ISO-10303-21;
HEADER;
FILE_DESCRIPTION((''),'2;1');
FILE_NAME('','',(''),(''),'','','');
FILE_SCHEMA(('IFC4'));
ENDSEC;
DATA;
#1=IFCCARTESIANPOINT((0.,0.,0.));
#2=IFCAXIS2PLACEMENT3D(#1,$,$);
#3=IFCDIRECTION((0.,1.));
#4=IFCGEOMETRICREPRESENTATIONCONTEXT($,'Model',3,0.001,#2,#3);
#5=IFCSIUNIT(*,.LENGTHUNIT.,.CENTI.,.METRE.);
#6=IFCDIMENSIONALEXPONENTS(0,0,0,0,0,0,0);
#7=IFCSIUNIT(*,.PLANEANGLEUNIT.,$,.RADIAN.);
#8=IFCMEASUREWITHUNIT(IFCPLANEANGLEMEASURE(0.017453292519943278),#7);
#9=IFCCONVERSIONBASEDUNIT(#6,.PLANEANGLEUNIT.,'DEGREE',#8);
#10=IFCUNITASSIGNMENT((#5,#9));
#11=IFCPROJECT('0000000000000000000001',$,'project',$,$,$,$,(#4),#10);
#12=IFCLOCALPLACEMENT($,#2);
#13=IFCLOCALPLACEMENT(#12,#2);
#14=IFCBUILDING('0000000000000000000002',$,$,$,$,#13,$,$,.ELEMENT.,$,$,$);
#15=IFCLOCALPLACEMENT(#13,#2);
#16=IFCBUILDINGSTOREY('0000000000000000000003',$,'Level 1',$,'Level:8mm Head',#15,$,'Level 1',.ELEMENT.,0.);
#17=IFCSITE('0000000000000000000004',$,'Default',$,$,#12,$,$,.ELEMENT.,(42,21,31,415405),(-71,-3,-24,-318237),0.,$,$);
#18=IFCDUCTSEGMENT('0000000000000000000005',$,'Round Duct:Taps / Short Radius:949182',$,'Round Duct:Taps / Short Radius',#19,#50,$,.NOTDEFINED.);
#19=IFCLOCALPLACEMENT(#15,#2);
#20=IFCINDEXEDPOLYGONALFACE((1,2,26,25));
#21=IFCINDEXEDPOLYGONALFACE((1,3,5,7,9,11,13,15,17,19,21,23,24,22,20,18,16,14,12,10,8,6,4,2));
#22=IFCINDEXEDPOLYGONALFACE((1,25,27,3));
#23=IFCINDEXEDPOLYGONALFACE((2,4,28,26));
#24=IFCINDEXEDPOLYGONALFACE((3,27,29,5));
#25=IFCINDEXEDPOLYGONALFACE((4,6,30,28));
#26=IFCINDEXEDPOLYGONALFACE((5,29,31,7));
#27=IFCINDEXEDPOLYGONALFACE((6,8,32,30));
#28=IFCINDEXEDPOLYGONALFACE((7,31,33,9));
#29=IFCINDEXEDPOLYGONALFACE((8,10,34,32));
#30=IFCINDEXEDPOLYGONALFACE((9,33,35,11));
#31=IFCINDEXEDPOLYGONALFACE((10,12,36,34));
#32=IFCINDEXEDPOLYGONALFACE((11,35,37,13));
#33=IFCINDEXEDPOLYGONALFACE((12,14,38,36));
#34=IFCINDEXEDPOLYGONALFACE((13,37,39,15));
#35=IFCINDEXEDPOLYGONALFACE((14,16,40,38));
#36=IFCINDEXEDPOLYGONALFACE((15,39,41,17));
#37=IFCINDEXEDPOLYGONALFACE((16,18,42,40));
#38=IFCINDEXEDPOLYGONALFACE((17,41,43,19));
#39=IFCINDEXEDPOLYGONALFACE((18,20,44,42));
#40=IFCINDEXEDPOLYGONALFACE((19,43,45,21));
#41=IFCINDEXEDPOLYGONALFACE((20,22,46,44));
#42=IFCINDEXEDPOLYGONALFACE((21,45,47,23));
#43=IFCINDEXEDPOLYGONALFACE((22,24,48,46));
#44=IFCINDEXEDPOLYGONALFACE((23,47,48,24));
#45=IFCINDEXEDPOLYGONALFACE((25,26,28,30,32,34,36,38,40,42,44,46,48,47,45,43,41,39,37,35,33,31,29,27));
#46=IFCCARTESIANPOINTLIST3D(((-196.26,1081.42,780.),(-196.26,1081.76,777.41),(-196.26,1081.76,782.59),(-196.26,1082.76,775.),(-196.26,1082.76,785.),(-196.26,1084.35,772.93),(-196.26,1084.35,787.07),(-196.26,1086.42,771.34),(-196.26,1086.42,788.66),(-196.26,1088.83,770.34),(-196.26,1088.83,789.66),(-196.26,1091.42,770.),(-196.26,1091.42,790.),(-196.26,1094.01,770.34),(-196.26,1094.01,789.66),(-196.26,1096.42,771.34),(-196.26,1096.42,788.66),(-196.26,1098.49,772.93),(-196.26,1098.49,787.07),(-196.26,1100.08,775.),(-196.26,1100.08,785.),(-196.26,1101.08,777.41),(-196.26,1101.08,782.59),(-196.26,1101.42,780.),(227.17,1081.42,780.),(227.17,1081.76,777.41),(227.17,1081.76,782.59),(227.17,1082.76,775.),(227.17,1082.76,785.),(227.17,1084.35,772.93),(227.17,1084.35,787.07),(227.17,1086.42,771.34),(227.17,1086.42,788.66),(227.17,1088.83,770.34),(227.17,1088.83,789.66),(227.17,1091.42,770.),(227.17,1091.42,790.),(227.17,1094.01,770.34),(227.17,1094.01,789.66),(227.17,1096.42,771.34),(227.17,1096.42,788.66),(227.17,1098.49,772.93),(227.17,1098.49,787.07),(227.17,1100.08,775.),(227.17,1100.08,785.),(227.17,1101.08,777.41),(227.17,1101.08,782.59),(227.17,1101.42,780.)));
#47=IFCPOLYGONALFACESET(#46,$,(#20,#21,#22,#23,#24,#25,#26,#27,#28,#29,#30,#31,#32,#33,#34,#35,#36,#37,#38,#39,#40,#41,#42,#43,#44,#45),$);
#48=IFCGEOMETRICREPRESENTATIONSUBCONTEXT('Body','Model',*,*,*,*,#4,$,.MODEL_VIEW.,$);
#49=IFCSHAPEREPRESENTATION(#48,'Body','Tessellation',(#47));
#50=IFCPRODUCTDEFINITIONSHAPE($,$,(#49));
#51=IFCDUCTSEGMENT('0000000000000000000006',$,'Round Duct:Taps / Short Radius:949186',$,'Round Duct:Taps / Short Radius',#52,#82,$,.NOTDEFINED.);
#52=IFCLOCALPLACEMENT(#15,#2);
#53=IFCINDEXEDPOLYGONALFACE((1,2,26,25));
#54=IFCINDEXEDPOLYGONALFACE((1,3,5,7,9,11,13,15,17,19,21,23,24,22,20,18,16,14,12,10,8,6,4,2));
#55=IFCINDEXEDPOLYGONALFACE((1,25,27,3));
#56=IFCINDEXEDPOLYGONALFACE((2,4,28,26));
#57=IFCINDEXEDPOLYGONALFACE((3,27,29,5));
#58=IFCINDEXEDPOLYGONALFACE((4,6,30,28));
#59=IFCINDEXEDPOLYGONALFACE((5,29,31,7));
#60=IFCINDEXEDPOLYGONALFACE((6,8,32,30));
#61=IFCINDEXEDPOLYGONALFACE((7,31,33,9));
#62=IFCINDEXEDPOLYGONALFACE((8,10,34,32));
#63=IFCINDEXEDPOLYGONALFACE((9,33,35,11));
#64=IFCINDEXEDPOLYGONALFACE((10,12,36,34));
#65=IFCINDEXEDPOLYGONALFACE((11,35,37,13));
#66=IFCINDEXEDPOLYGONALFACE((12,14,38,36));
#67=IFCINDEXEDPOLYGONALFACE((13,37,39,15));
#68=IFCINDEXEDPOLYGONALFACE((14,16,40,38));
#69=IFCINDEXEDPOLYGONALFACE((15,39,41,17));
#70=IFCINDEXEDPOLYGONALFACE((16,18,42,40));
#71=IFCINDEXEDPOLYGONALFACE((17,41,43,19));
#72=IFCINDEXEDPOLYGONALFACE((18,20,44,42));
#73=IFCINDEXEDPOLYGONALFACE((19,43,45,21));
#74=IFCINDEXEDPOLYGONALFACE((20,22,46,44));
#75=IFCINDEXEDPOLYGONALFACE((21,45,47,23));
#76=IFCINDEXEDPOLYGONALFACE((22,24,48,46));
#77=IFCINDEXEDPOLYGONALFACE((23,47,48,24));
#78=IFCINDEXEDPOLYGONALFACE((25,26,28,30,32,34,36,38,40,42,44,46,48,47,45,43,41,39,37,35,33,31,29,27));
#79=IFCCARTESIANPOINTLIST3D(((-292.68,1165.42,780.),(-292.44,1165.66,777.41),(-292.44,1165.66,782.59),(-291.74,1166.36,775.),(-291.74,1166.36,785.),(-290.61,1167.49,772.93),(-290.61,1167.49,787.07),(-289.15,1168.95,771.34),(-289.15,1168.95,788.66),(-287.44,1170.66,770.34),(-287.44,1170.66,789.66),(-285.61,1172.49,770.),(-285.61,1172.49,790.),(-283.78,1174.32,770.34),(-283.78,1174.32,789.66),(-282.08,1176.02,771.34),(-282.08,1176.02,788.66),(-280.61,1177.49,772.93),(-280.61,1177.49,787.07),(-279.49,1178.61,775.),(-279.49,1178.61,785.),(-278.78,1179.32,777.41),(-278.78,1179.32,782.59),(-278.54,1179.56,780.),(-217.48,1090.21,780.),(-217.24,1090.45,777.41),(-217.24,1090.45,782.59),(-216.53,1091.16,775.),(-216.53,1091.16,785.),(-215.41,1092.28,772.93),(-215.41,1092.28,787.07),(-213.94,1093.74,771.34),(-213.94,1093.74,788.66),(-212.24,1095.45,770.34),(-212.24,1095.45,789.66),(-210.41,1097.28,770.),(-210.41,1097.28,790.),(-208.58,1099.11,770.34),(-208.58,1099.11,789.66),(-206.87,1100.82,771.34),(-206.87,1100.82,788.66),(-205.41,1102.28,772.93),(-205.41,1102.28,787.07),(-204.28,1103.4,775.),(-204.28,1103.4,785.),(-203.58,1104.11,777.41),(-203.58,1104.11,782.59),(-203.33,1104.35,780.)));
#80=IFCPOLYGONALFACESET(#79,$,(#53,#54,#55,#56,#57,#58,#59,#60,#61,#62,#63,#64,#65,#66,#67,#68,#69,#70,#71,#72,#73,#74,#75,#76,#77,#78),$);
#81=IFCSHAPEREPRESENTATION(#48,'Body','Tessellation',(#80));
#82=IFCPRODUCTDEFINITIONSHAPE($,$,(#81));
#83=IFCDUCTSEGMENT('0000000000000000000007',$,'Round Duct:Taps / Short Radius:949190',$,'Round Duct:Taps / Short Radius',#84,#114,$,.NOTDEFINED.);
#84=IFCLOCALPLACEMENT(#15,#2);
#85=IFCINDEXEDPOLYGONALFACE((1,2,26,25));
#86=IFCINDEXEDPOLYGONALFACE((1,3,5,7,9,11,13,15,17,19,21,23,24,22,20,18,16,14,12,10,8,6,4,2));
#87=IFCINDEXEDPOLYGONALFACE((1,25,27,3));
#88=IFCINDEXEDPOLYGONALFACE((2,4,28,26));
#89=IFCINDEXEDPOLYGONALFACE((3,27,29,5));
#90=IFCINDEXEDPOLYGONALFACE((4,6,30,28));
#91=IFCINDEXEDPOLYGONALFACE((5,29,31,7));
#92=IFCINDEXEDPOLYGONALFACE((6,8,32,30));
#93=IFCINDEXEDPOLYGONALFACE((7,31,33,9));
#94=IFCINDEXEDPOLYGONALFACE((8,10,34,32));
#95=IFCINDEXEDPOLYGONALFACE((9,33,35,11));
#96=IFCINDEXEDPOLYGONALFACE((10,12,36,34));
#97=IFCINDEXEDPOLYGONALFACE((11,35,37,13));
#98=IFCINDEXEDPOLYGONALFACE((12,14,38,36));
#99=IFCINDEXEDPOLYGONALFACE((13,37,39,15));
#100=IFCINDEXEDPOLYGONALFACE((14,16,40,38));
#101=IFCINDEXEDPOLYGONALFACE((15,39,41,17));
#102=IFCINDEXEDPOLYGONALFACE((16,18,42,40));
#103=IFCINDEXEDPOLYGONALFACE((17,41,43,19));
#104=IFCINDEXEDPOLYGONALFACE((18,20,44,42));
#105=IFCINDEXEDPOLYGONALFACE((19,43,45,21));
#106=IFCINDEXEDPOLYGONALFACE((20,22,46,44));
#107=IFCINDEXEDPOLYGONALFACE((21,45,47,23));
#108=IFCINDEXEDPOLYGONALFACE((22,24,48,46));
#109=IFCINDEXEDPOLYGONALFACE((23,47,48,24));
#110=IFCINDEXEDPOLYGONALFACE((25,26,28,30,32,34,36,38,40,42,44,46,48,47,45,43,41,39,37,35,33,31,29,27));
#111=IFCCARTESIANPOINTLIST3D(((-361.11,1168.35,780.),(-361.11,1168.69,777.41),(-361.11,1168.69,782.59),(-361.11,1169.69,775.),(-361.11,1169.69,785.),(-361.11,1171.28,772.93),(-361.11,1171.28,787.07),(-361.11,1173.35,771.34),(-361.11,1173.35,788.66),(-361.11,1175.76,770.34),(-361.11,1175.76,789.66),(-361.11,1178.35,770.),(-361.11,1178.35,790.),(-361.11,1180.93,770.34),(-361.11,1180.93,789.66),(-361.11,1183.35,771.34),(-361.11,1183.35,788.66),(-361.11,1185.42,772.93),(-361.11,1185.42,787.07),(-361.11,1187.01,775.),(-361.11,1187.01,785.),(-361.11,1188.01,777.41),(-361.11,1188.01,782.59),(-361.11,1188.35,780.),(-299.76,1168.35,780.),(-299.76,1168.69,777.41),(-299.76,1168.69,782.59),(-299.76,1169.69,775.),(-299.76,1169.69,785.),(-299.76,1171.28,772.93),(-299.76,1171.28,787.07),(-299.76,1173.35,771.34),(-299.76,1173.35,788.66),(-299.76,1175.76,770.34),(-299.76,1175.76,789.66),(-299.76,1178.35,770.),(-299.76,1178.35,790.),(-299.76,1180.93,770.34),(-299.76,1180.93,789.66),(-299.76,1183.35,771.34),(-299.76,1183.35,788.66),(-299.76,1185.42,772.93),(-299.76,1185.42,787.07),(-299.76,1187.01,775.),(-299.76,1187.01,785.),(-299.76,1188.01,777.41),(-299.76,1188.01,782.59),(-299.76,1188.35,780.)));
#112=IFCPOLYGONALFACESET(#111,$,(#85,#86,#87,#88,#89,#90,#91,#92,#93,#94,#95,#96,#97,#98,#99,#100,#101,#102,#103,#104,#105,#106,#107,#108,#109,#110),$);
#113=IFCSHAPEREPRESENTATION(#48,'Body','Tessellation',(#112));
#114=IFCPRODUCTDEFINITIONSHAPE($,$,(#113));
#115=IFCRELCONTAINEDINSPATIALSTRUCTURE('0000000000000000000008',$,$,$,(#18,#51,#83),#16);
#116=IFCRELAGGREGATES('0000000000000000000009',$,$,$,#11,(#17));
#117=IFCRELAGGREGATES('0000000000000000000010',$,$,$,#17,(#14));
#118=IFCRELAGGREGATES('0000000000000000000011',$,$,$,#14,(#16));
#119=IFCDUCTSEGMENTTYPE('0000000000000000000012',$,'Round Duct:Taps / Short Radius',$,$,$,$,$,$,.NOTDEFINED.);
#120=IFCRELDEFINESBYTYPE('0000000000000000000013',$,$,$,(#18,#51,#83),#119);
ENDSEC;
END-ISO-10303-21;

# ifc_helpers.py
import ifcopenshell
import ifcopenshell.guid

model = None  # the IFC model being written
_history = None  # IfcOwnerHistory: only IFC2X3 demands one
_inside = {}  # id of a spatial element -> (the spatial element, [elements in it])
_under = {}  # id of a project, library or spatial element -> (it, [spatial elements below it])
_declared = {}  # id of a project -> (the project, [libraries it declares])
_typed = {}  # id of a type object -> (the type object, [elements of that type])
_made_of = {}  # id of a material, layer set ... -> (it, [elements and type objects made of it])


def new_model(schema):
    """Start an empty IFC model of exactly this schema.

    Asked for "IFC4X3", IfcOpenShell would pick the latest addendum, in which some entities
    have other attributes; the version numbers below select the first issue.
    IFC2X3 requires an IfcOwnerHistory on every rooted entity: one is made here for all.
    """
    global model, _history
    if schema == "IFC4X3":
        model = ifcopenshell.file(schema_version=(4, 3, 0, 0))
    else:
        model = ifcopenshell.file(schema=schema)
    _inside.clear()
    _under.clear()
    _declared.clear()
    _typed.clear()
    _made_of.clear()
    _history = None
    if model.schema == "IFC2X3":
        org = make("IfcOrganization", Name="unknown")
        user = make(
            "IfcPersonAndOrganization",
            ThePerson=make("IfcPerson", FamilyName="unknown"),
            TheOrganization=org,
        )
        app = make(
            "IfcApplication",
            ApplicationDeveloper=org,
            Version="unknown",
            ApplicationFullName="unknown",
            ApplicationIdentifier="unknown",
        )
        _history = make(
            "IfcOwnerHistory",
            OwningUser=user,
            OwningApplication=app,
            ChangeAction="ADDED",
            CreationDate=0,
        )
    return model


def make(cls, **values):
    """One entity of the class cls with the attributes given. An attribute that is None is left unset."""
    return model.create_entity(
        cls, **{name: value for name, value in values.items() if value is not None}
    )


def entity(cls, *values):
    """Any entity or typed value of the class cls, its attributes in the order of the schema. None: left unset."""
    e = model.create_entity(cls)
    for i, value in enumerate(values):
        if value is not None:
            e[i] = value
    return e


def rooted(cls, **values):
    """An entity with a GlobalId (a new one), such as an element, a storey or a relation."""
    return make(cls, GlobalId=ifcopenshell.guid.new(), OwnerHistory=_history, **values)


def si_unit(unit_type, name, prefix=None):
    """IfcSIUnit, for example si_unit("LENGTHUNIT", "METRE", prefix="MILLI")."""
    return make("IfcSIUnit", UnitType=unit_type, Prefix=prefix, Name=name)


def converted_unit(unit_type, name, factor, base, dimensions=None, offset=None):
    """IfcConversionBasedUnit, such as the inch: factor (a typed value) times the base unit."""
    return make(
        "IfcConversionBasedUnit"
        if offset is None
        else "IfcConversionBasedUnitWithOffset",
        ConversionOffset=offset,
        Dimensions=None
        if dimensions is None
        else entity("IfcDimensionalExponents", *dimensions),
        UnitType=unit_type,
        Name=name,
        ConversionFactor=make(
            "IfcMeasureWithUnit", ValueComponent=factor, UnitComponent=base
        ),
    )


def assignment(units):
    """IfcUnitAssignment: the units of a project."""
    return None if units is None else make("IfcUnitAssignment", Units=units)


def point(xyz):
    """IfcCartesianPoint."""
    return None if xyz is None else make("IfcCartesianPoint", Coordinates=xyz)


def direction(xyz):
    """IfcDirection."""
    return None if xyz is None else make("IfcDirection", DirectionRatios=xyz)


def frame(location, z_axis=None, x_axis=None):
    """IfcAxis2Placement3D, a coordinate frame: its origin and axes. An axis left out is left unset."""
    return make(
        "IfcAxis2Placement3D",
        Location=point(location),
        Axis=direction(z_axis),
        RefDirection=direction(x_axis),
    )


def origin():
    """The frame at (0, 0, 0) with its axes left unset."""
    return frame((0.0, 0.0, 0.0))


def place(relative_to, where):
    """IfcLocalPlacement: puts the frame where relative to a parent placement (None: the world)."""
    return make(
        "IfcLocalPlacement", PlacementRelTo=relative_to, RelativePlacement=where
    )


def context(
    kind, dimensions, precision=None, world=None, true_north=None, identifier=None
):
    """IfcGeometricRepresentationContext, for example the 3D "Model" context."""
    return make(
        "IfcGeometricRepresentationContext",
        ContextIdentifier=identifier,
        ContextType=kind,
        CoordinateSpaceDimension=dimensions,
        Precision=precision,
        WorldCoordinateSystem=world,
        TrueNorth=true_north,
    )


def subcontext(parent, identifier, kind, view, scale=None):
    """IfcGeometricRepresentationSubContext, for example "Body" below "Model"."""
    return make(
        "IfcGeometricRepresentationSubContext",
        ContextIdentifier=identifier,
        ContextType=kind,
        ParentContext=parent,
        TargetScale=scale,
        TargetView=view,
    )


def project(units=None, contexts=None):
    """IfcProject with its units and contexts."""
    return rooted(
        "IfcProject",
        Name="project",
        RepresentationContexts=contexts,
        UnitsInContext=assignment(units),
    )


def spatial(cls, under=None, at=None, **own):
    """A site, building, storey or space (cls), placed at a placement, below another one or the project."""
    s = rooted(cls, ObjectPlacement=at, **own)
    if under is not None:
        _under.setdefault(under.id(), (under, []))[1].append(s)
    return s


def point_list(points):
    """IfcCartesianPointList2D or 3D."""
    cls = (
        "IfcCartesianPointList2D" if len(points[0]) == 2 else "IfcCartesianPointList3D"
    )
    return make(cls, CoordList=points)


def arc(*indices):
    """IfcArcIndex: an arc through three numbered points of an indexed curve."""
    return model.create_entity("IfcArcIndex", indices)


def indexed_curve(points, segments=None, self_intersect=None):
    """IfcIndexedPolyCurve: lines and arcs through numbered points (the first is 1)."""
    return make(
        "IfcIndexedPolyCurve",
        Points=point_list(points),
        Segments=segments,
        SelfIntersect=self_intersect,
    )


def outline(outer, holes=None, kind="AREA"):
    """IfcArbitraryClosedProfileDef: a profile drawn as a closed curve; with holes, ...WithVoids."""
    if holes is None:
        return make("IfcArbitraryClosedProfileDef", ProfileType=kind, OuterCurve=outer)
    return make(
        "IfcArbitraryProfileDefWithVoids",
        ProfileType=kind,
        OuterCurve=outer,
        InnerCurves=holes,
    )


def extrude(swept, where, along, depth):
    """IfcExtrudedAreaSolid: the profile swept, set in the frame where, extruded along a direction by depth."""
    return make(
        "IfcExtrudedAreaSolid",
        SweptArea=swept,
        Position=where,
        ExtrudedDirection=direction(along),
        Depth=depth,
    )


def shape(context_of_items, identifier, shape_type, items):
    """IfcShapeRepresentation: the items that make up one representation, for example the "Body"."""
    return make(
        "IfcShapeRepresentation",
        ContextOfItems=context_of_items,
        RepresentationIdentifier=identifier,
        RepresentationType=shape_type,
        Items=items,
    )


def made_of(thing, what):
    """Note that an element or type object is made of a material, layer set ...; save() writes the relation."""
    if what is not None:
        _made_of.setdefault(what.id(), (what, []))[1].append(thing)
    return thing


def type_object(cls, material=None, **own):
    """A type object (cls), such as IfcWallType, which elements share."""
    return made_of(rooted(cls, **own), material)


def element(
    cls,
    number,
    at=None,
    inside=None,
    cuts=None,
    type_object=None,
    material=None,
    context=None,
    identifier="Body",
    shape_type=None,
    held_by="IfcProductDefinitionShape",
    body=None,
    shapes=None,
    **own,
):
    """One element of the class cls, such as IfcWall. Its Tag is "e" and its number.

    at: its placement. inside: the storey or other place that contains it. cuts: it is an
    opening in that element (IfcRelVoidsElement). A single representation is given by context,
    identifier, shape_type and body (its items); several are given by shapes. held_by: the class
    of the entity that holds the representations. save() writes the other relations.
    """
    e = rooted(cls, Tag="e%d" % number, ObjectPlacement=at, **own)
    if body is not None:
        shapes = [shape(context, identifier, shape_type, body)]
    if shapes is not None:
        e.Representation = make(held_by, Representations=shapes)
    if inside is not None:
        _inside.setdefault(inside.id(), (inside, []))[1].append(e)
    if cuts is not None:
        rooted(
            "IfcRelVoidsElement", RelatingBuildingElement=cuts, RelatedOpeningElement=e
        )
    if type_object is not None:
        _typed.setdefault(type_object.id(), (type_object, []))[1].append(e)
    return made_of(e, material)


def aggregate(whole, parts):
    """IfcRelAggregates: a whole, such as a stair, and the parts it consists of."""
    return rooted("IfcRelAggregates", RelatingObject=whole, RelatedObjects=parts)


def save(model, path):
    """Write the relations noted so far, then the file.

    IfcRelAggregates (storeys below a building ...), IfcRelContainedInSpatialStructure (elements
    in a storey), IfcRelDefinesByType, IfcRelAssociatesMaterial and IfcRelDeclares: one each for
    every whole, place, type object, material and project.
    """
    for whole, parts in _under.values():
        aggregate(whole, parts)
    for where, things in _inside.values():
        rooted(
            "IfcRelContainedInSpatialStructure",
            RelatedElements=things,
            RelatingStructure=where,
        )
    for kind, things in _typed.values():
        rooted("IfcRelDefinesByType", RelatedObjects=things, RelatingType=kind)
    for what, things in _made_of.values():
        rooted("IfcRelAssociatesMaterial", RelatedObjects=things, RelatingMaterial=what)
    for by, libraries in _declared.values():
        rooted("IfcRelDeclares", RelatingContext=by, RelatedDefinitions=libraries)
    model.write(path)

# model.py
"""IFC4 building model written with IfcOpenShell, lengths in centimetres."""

from ifc_helpers import new_model, entity, si_unit, converted_unit, direction, frame, origin, place, context, subcontext, project, spatial, arc, indexed_curve, outline, extrude, type_object, element, save


model = new_model("IFC4")

# Units and contexts
model_context = context("Model", 3, precision=0.001, world=origin(), true_north=direction((0.0, 1.0)))
body_context = subcontext(model_context, "Body", "Model", "MODEL_VIEW")
ifc_project = project(units=[si_unit("LENGTHUNIT", "METRE", prefix="CENTI"), converted_unit("PLANEANGLEUNIT", "DEGREE", entity("IfcPlaneAngleMeasure", 0.017453292519943278), si_unit("PLANEANGLEUNIT", "RADIAN"), dimensions=[0, 0, 0, 0, 0, 0, 0])], contexts=[model_context])

# Site, building, storey
site_placement = place(None, origin())
site = spatial("IfcSite", under=ifc_project, at=site_placement, Name="Default", CompositionType="ELEMENT", RefLatitude=(42, 21, 31, 415405), RefLongitude=(-71, -3, -24, -318237), RefElevation=0.0)
building_placement = place(site_placement, origin())
building = spatial("IfcBuilding", under=site, at=building_placement, CompositionType="ELEMENT")
storey_placement = place(building_placement, origin())
storey = spatial("IfcBuildingStorey", under=building, at=storey_placement, Name="Level 1", ObjectType="Level:8mm Head", LongName="Level 1", CompositionType="ELEMENT", Elevation=0.0)

# Duct segments
duct_segment_type_1 = type_object("IfcDuctSegmentType", Name="Round Duct:Taps / Short Radius", PredefinedType="NOTDEFINED")
duct_segment_1_placement = place(storey_placement, origin())
element("IfcDuctSegment", 1, at=duct_segment_1_placement, inside=storey, type_object=duct_segment_type_1, Name="Round Duct:Taps / Short Radius:949182", ObjectType="Round Duct:Taps / Short Radius", PredefinedType="NOTDEFINED", context=body_context, shape_type="SweptSolid", body=[
    extrude(outline(indexed_curve([(10.0, 0.0), (7.07, 7.07), (0.0, 10.0), (-7.07, 7.07), (-10.0, 0.0), (-7.07, -7.07), (0.0, -10.0), (7.07, -7.07)], segments=[arc(1, 2, 3), arc(3, 4, 5), arc(5, 6, 7), arc(7, 8, 1)], self_intersect=False)), frame((-196.26, 1091.42, 780.0), z_axis=(1.0, 0.0, 0.0), x_axis=(0.0, 1.0, 0.0)), (0.0, 0.0, 1.0), 423.43),
])
duct_segment_2_placement = place(storey_placement, origin())
element("IfcDuctSegment", 2, at=duct_segment_2_placement, inside=storey, type_object=duct_segment_type_1, Name="Round Duct:Taps / Short Radius:949186", ObjectType="Round Duct:Taps / Short Radius", PredefinedType="NOTDEFINED", context=body_context, shape_type="SweptSolid", body=[
    extrude(outline(indexed_curve([(10.0, 0.0), (7.07, 7.07), (0.0, 10.0), (-7.07, 7.07), (-10.0, 0.0), (-7.07, -7.07), (0.0, -10.0), (7.07, -7.07)], segments=[arc(1, 2, 3), arc(3, 4, 5), arc(5, 6, 7), arc(7, 8, 1)], self_intersect=False)), frame((-285.61, 1172.49, 780.0), z_axis=(0.707107, -0.707107, 0.0), x_axis=(0.707107, 0.707107, 0.0)), (0.0, 0.0, 1.0), 106.36),
])
duct_segment_3_placement = place(storey_placement, origin())
element("IfcDuctSegment", 3, at=duct_segment_3_placement, inside=storey, type_object=duct_segment_type_1, Name="Round Duct:Taps / Short Radius:949190", ObjectType="Round Duct:Taps / Short Radius", PredefinedType="NOTDEFINED", context=body_context, shape_type="SweptSolid", body=[
    extrude(outline(indexed_curve([(10.0, 0.0), (7.07, 7.07), (0.0, 10.0), (-7.07, 7.07), (-10.0, 0.0), (-7.07, -7.07), (0.0, -10.0), (7.07, -7.07)], segments=[arc(1, 2, 3), arc(3, 4, 5), arc(5, 6, 7), arc(7, 8, 1)], self_intersect=False)), frame((-361.11, 1178.35, 780.0), z_axis=(1.0, 0.0, 0.0), x_axis=(0.0, 1.0, 0.0)), (0.0, 0.0, 1.0), 61.35),
])

save(model, "model.ifc")
